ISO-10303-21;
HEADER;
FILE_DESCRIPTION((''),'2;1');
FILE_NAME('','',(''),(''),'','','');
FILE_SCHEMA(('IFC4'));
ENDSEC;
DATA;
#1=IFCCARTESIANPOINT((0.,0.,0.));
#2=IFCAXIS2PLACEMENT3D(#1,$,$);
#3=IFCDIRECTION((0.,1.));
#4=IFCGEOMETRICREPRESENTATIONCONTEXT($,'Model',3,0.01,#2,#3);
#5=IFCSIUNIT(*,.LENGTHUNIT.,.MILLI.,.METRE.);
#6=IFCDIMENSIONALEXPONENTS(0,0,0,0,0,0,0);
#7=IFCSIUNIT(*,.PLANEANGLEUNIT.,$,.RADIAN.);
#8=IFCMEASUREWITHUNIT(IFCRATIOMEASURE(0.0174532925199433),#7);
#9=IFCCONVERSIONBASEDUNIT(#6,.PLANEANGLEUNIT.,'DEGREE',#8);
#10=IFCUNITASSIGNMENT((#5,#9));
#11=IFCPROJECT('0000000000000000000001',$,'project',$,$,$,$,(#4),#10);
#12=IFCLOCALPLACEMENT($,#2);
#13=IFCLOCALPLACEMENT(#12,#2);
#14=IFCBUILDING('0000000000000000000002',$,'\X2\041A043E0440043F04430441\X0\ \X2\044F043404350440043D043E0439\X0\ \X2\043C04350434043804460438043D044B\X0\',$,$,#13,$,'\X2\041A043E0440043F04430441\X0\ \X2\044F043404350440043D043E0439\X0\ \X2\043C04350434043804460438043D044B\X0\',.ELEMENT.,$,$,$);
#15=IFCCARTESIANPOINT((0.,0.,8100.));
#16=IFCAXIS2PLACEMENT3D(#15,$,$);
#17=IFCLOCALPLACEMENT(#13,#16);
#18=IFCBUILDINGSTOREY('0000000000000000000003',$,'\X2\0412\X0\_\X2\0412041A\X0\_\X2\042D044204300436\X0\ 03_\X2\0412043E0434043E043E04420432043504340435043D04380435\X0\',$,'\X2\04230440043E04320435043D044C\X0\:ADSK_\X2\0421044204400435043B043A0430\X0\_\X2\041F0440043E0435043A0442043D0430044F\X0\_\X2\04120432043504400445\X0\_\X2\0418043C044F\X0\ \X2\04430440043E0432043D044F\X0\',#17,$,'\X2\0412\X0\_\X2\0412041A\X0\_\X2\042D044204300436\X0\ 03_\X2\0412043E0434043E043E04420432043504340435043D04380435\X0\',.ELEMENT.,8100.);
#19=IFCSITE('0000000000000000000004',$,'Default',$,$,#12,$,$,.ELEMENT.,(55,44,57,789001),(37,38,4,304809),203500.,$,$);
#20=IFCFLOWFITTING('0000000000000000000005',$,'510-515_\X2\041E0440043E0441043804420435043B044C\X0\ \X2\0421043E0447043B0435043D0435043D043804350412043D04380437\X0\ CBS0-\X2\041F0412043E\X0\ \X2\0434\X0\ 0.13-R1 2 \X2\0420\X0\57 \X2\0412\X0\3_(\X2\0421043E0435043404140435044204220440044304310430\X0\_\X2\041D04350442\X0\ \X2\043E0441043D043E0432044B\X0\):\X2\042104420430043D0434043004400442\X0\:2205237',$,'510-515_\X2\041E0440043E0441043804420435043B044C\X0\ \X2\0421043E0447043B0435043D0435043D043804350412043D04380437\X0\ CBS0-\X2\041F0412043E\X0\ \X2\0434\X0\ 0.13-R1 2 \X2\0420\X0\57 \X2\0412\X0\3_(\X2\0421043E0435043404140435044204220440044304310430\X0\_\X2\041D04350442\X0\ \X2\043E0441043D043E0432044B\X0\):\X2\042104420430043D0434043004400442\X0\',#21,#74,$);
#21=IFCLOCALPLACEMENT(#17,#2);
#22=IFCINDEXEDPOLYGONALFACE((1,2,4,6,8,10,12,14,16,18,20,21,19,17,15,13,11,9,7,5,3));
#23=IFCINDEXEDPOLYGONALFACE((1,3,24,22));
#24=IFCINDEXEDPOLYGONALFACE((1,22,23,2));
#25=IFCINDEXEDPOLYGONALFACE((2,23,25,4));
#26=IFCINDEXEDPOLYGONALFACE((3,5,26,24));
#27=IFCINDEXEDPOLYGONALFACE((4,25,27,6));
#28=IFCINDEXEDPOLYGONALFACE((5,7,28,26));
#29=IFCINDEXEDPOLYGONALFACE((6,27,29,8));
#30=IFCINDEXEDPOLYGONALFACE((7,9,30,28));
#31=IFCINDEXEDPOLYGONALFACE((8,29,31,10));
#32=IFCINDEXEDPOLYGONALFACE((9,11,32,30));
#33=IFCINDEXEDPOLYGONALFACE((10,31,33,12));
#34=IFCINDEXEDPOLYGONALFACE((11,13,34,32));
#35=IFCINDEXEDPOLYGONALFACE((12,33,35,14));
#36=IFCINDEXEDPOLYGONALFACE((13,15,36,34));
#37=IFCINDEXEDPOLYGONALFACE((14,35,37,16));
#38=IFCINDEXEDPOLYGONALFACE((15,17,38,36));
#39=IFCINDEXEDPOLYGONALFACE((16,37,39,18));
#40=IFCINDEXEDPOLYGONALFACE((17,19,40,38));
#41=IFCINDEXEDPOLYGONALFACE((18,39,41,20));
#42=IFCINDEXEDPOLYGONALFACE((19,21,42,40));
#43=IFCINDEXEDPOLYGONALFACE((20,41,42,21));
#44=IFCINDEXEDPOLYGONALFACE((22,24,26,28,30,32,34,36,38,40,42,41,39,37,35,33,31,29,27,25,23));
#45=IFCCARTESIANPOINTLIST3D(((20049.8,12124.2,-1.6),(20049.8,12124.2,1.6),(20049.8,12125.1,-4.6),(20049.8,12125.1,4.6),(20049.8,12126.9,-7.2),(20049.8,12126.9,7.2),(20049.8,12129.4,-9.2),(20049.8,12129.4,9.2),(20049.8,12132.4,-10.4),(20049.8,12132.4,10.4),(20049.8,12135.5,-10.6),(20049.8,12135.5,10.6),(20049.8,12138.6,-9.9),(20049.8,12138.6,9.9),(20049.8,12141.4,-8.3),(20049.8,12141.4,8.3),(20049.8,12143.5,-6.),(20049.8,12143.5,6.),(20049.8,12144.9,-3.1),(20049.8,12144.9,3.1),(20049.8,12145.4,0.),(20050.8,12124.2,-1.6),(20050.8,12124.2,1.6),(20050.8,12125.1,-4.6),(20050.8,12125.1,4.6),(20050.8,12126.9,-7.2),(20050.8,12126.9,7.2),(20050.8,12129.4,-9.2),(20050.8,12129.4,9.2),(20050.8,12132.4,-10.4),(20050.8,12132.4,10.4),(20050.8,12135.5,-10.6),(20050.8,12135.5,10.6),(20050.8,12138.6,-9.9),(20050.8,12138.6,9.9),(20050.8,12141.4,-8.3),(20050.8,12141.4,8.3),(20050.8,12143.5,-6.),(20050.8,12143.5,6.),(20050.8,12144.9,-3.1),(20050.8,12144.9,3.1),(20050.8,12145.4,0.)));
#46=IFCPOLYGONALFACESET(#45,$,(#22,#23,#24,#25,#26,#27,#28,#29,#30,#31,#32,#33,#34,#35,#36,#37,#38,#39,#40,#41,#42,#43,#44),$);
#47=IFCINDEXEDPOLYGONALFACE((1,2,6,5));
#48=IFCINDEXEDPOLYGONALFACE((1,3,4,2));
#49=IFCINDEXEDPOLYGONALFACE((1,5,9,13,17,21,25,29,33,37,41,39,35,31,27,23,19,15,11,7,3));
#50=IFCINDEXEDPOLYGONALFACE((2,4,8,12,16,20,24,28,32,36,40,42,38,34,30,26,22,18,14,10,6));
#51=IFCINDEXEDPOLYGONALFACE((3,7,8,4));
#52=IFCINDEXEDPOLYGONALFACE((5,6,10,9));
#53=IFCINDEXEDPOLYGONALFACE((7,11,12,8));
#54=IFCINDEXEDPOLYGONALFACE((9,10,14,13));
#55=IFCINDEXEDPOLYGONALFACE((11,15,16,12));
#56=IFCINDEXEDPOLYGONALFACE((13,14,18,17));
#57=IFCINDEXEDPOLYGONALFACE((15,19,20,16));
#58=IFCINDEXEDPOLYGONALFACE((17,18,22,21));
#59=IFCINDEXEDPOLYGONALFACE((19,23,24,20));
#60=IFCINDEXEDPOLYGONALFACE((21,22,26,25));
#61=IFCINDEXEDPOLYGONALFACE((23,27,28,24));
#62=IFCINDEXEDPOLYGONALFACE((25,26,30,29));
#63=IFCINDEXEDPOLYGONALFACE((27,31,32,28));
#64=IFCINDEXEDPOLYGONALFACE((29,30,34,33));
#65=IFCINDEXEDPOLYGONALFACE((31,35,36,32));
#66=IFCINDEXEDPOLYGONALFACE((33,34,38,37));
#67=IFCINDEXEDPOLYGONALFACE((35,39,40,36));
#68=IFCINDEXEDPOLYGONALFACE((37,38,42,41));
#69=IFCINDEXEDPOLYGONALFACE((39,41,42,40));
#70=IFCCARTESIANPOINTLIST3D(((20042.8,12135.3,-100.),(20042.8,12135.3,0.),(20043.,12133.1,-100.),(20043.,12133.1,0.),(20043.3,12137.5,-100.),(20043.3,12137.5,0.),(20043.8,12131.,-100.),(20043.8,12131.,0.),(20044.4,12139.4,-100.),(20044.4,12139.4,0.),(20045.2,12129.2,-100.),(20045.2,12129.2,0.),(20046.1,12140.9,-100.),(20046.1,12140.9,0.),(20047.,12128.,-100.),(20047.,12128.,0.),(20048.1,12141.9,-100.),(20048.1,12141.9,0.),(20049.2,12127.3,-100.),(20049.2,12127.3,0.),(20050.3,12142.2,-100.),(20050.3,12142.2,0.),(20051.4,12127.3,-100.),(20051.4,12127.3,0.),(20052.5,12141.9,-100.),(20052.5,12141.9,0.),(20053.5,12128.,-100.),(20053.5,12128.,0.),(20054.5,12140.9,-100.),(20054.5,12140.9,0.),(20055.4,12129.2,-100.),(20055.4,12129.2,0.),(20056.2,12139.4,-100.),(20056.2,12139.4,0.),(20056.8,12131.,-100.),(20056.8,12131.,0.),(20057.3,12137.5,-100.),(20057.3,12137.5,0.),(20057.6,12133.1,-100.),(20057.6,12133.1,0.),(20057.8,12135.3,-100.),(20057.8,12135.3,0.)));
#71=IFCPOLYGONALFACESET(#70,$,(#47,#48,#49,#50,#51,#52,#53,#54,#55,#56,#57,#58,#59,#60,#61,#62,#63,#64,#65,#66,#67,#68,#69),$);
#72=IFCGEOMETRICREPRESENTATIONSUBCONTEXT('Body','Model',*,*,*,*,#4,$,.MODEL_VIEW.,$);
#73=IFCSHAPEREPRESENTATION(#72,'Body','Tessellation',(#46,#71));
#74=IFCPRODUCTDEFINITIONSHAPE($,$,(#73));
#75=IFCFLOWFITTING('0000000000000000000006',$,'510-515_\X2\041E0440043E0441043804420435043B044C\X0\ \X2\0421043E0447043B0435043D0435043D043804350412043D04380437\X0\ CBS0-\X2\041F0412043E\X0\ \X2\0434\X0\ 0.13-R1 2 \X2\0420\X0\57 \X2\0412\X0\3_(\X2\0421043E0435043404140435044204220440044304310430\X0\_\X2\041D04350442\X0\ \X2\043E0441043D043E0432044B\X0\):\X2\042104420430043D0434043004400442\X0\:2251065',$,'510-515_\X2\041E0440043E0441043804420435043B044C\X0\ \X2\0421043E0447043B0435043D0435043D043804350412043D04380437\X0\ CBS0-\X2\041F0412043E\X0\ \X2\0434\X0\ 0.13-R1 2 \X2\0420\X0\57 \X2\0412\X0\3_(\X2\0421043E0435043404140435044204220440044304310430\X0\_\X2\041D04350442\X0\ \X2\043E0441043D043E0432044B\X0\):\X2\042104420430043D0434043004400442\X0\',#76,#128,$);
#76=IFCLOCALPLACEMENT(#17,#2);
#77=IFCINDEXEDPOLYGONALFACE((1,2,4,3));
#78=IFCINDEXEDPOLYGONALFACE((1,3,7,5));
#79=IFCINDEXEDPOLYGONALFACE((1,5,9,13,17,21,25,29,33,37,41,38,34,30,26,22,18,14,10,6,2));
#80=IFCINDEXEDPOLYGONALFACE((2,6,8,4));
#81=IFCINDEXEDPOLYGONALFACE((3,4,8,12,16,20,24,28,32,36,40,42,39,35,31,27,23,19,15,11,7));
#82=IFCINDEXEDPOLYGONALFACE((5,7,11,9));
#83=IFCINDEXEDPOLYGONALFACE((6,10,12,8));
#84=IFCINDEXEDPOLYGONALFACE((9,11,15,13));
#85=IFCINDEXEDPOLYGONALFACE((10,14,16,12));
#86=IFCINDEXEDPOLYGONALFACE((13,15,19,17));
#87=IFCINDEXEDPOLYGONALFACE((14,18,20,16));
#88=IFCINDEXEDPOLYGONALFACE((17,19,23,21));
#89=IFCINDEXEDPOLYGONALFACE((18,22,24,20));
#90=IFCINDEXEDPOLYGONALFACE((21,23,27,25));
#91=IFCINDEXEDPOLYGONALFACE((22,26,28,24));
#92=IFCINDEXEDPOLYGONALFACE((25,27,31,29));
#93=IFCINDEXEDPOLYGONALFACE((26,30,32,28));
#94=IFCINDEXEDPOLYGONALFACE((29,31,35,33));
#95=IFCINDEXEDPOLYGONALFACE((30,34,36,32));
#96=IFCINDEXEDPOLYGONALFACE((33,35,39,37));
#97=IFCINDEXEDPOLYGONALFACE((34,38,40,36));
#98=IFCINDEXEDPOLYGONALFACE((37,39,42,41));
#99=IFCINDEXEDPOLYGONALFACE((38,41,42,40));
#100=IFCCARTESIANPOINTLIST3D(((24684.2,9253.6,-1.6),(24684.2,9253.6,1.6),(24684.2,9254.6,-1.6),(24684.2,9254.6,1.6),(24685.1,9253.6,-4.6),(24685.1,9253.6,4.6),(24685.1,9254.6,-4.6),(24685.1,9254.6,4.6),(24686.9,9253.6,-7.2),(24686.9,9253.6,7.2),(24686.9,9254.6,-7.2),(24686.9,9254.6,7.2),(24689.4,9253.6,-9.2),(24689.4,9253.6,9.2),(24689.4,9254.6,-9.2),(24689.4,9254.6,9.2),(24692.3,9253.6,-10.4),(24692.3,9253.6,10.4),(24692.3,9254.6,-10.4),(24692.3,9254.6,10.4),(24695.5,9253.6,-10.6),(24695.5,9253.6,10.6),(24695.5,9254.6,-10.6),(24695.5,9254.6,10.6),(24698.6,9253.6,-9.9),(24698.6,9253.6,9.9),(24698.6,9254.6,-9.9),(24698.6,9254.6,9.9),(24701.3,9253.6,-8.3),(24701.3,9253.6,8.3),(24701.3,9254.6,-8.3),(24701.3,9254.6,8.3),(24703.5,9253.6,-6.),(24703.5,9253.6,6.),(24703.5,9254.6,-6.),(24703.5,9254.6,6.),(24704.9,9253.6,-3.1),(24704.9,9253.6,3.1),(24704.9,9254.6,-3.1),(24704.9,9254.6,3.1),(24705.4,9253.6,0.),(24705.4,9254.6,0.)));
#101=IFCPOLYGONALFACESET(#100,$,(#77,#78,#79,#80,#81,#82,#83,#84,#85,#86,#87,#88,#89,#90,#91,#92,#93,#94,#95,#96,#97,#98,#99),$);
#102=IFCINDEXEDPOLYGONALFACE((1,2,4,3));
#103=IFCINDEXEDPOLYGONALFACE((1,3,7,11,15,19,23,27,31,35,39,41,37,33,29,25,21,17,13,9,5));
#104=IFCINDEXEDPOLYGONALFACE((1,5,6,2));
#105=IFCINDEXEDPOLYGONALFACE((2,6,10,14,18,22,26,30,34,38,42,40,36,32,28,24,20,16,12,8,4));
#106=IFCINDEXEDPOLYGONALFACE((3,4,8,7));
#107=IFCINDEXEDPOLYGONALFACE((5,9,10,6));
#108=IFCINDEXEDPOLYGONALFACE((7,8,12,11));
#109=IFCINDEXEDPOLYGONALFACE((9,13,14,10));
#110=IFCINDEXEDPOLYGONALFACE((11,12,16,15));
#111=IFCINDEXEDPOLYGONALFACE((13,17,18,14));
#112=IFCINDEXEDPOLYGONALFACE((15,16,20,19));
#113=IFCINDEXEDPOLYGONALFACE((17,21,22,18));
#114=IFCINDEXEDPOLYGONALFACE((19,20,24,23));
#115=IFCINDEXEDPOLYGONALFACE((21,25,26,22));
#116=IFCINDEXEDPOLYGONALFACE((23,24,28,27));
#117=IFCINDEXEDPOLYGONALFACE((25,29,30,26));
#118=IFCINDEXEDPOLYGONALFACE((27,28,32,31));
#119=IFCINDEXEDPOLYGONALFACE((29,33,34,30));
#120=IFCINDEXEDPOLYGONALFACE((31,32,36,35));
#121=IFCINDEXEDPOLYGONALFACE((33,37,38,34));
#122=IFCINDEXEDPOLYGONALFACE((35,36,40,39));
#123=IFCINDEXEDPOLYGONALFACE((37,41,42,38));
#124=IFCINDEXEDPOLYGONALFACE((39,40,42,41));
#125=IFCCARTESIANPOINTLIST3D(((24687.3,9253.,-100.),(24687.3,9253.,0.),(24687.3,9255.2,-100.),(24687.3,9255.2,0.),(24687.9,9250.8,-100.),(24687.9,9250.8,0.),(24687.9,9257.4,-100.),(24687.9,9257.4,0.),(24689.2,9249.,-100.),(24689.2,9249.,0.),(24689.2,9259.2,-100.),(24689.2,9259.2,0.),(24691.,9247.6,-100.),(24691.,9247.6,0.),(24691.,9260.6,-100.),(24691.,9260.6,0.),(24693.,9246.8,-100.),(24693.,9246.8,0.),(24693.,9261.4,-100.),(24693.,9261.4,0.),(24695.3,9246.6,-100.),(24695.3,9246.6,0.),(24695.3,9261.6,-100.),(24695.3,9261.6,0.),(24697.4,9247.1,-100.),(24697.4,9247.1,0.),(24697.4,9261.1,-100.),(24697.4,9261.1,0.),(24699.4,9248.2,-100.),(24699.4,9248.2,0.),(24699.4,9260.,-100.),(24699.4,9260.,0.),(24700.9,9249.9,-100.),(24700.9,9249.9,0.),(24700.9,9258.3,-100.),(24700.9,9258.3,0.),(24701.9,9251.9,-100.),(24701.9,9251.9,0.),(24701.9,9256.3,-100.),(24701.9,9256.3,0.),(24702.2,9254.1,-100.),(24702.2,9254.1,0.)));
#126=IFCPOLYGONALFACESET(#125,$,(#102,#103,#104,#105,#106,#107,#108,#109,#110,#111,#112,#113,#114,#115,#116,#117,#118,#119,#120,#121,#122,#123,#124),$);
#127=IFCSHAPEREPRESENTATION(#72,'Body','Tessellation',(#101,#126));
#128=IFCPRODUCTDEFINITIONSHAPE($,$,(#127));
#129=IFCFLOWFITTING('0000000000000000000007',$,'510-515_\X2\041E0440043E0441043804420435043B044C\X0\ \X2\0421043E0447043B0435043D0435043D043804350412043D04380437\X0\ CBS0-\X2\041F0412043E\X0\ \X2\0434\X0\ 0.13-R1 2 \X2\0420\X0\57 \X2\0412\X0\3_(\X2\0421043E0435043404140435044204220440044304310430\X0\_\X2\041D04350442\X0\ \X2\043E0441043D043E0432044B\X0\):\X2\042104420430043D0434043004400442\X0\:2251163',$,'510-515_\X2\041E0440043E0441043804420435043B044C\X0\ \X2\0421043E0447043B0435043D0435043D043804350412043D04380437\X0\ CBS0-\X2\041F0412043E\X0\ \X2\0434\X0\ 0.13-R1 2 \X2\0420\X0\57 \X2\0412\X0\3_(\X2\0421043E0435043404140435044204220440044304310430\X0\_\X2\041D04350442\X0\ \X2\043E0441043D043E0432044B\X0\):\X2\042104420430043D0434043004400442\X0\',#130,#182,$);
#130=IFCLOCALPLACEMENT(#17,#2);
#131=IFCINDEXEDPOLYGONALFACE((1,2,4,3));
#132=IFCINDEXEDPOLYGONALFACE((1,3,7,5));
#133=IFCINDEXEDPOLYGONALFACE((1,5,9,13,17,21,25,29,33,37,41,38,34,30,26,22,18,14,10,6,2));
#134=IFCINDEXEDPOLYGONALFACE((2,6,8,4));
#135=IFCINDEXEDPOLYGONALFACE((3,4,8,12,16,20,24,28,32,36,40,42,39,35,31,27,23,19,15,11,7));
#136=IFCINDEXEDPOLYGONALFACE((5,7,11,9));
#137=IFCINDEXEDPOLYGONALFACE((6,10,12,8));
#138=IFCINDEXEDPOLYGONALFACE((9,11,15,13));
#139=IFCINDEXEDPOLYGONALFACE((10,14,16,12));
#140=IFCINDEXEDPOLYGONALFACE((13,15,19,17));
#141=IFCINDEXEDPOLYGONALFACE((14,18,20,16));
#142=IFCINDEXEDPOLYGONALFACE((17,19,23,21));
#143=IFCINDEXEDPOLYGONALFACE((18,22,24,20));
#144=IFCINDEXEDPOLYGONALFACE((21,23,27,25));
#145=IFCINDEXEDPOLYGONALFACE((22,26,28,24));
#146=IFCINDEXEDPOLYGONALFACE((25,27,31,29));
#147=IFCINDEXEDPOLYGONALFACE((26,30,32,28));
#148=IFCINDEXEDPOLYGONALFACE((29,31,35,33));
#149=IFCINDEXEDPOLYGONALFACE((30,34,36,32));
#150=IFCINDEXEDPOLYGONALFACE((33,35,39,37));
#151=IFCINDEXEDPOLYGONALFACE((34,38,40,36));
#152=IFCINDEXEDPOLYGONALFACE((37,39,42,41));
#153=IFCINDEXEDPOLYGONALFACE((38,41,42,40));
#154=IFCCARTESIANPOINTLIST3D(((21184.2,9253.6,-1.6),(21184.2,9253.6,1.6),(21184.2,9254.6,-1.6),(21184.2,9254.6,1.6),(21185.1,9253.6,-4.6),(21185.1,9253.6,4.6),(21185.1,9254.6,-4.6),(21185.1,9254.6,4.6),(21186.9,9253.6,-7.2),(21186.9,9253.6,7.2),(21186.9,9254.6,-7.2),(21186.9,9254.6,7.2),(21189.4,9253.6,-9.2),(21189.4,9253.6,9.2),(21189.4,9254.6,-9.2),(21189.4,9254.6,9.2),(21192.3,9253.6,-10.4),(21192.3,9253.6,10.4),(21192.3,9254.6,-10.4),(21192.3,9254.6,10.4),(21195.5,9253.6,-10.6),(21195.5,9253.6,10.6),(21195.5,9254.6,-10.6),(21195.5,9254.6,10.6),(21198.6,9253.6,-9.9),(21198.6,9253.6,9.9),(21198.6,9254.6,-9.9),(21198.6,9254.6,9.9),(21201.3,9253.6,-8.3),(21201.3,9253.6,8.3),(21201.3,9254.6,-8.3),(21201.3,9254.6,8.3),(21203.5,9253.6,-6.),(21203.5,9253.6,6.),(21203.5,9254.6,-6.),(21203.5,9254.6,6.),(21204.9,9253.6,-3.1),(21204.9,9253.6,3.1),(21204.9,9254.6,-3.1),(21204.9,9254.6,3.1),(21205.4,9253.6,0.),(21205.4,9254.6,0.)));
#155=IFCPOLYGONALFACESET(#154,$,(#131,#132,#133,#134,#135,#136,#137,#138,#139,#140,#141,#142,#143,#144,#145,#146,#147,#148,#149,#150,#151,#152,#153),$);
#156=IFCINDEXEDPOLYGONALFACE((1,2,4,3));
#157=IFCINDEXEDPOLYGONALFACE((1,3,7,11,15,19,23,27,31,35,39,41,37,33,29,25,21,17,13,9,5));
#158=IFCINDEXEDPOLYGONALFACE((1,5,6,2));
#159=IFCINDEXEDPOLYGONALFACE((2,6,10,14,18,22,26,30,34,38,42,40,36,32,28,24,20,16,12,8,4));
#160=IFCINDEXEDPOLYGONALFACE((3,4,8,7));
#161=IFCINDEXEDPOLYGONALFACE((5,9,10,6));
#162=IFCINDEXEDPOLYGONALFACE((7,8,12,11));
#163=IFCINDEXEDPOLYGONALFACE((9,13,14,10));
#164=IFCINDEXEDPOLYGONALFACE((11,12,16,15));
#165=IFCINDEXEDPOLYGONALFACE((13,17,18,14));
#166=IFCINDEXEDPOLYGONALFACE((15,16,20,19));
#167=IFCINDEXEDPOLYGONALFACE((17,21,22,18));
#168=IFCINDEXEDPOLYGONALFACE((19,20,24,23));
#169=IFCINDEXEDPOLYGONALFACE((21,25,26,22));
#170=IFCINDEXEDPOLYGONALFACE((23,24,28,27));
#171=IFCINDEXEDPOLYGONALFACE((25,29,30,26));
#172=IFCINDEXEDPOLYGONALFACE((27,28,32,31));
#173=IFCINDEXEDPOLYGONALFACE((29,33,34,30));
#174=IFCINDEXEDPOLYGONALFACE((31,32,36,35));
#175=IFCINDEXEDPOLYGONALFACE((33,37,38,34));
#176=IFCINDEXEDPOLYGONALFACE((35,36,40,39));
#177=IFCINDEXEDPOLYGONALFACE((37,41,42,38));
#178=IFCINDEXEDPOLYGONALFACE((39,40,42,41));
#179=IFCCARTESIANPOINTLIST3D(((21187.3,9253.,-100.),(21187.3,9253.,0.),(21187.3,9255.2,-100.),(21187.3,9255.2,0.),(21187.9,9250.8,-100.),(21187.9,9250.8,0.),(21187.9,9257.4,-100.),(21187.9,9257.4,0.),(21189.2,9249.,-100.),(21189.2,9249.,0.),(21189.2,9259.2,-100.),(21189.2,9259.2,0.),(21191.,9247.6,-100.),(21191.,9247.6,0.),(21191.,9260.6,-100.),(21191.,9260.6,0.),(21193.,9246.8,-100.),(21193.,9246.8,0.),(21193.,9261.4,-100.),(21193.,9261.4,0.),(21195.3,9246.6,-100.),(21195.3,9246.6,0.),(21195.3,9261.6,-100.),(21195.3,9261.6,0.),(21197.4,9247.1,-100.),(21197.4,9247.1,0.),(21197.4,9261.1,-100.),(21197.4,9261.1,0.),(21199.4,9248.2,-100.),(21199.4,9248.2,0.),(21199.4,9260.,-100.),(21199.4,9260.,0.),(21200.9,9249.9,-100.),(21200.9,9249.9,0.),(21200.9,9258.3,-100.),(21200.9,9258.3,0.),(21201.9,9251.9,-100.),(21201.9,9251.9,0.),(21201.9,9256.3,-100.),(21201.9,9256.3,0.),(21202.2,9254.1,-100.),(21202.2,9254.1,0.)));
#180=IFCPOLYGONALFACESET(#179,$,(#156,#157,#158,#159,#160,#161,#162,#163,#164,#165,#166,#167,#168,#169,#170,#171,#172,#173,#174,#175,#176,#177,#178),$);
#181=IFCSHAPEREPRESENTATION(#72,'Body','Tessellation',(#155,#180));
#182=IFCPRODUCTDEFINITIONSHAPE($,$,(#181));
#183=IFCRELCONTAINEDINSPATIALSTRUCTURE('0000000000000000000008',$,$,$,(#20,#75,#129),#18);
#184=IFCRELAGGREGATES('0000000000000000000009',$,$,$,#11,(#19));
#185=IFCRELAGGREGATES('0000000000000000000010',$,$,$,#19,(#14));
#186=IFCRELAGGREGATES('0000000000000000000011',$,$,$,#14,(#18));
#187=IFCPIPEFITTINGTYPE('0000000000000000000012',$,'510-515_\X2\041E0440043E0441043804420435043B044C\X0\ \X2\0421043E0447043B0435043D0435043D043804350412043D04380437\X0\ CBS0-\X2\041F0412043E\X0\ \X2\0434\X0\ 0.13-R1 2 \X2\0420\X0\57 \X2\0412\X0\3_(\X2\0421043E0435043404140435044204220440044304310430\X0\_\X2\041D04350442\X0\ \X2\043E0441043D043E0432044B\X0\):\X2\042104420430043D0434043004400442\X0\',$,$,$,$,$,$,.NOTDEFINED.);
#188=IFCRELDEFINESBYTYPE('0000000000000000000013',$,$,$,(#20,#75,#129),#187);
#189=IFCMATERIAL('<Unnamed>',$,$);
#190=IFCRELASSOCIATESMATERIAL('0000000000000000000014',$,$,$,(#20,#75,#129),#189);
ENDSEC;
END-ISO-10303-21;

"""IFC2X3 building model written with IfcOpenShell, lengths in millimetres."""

from ifc_helpers import new_model, entity, si_unit, converted_unit, direction, frame, origin, origin_2d_with_axis, place, context, subcontext, project, spatial, circle, extrude, source, transform, mapped, material, type_object, type_shapes, element, save


model = new_model("IFC2X3")

# Units and contexts
model_context = context("Model", 3, precision=0.01, world=origin(), true_north=direction((0.0, 1.0)))
body_context = subcontext(model_context, "Body", "Model", "MODEL_VIEW")
ifc_project = project(units=[si_unit("LENGTHUNIT", "METRE", prefix="MILLI"), converted_unit("PLANEANGLEUNIT", "DEGREE", entity("IfcRatioMeasure", 0.0174532925199433), si_unit("PLANEANGLEUNIT", "RADIAN"), dimensions=[0, 0, 0, 0, 0, 0, 0])], contexts=[model_context])

# Site, building, storey
site_placement = place(None, origin())
site = spatial("IfcSite", under=ifc_project, at=site_placement, Name="Default", CompositionType="ELEMENT", RefLatitude=(55, 44, 57, 789001), RefLongitude=(37, 38, 4, 304809), RefElevation=203500.0)
building_placement = place(site_placement, origin())
building = spatial("IfcBuilding", under=site, at=building_placement, Name="Корпус ядерной медицины", LongName="Корпус ядерной медицины", CompositionType="ELEMENT")
storey_placement = place(building_placement, frame((0.0, 0.0, 8100.0)))
storey = spatial("IfcBuildingStorey", under=building, at=storey_placement, Name="В_ВК_Этаж 03_Водоотведение", ObjectType="Уровень:ADSK_Стрелка_Проектная_Вверх_Имя уровня", LongName="В_ВК_Этаж 03_Водоотведение", CompositionType="ELEMENT", Elevation=8100.0)

# Flow fittings
ifc_material_1 = material(Name="<Unnamed>")
pipe_fitting_type_1 = type_object("IfcPipeFittingType", Name="510-515_Ороситель СочленениеВниз CBS0-ПВо д 0.13-R1 2 Р57 В3_(СоедДетТруба_Нет основы):Стандарт", PredefinedType="NOTDEFINED")
shared_shape_1 = source(origin(), body_context, "Body", "SweptSolid", [
    extrude(circle(Radius=10.7, at=origin_2d_with_axis()), frame((-0.5, 0.0, 0.0), z_axis=(1.0, 0.0, 0.0), x_axis=(0.0, 1.0, 0.0)), (0.0, 0.0, 1.0), 1.0),
    extrude(circle(Radius=7.5, at=origin_2d_with_axis()), frame((0.0, 0.0, -100.0), z_axis=(0.0, 0.0, 1.0), x_axis=(0.0, 1.0, 0.0)), (0.0, 0.0, 1.0), 100.0),
])
type_shapes(pipe_fitting_type_1, [shared_shape_1])
for number, where, name in (
    (1, (20050.3, 12134.7, 0.0), "510-515_Ороситель СочленениеВниз CBS0-ПВо д 0.13-R1 2 Р57 В3_(СоедДетТруба_Нет основы):Стандарт:2205237"),
):
    element("IfcFlowFitting", number, at=place(storey_placement, frame(where)), inside=storey, type_object=pipe_fitting_type_1, material=ifc_material_1, Name=name, ObjectType="510-515_Ороситель СочленениеВниз CBS0-ПВо д 0.13-R1 2 Р57 В3_(СоедДетТруба_Нет основы):Стандарт", context=body_context, shape_type="MappedRepresentation", body=[
        mapped(shared_shape_1, transform((0.0, 0.0, 0.0), scale=1.0)),
    ])
for number, where, z_axis, x_axis, name in (
    (2, (24694.7, 9254.1, 0.0), (0.0, 0.0, 1.0), (0.0, -1.0, 0.0), "510-515_Ороситель СочленениеВниз CBS0-ПВо д 0.13-R1 2 Р57 В3_(СоедДетТруба_Нет основы):Стандарт:2251065"),
    (3, (21194.7, 9254.1, 0.0), (0.0, 0.0, 1.0), (0.0, -1.0, 0.0), "510-515_Ороситель СочленениеВниз CBS0-ПВо д 0.13-R1 2 Р57 В3_(СоедДетТруба_Нет основы):Стандарт:2251163"),
):
    element("IfcFlowFitting", number, at=place(storey_placement, frame(where, z_axis=z_axis, x_axis=x_axis)), inside=storey, type_object=pipe_fitting_type_1, material=ifc_material_1, Name=name, ObjectType="510-515_Ороситель СочленениеВниз CBS0-ПВо д 0.13-R1 2 Р57 В3_(СоедДетТруба_Нет основы):Стандарт", context=body_context, shape_type="MappedRepresentation", body=[
        mapped(shared_shape_1, transform((0.0, 0.0, 0.0), scale=1.0)),
    ])

save(model, "model.ifc")
